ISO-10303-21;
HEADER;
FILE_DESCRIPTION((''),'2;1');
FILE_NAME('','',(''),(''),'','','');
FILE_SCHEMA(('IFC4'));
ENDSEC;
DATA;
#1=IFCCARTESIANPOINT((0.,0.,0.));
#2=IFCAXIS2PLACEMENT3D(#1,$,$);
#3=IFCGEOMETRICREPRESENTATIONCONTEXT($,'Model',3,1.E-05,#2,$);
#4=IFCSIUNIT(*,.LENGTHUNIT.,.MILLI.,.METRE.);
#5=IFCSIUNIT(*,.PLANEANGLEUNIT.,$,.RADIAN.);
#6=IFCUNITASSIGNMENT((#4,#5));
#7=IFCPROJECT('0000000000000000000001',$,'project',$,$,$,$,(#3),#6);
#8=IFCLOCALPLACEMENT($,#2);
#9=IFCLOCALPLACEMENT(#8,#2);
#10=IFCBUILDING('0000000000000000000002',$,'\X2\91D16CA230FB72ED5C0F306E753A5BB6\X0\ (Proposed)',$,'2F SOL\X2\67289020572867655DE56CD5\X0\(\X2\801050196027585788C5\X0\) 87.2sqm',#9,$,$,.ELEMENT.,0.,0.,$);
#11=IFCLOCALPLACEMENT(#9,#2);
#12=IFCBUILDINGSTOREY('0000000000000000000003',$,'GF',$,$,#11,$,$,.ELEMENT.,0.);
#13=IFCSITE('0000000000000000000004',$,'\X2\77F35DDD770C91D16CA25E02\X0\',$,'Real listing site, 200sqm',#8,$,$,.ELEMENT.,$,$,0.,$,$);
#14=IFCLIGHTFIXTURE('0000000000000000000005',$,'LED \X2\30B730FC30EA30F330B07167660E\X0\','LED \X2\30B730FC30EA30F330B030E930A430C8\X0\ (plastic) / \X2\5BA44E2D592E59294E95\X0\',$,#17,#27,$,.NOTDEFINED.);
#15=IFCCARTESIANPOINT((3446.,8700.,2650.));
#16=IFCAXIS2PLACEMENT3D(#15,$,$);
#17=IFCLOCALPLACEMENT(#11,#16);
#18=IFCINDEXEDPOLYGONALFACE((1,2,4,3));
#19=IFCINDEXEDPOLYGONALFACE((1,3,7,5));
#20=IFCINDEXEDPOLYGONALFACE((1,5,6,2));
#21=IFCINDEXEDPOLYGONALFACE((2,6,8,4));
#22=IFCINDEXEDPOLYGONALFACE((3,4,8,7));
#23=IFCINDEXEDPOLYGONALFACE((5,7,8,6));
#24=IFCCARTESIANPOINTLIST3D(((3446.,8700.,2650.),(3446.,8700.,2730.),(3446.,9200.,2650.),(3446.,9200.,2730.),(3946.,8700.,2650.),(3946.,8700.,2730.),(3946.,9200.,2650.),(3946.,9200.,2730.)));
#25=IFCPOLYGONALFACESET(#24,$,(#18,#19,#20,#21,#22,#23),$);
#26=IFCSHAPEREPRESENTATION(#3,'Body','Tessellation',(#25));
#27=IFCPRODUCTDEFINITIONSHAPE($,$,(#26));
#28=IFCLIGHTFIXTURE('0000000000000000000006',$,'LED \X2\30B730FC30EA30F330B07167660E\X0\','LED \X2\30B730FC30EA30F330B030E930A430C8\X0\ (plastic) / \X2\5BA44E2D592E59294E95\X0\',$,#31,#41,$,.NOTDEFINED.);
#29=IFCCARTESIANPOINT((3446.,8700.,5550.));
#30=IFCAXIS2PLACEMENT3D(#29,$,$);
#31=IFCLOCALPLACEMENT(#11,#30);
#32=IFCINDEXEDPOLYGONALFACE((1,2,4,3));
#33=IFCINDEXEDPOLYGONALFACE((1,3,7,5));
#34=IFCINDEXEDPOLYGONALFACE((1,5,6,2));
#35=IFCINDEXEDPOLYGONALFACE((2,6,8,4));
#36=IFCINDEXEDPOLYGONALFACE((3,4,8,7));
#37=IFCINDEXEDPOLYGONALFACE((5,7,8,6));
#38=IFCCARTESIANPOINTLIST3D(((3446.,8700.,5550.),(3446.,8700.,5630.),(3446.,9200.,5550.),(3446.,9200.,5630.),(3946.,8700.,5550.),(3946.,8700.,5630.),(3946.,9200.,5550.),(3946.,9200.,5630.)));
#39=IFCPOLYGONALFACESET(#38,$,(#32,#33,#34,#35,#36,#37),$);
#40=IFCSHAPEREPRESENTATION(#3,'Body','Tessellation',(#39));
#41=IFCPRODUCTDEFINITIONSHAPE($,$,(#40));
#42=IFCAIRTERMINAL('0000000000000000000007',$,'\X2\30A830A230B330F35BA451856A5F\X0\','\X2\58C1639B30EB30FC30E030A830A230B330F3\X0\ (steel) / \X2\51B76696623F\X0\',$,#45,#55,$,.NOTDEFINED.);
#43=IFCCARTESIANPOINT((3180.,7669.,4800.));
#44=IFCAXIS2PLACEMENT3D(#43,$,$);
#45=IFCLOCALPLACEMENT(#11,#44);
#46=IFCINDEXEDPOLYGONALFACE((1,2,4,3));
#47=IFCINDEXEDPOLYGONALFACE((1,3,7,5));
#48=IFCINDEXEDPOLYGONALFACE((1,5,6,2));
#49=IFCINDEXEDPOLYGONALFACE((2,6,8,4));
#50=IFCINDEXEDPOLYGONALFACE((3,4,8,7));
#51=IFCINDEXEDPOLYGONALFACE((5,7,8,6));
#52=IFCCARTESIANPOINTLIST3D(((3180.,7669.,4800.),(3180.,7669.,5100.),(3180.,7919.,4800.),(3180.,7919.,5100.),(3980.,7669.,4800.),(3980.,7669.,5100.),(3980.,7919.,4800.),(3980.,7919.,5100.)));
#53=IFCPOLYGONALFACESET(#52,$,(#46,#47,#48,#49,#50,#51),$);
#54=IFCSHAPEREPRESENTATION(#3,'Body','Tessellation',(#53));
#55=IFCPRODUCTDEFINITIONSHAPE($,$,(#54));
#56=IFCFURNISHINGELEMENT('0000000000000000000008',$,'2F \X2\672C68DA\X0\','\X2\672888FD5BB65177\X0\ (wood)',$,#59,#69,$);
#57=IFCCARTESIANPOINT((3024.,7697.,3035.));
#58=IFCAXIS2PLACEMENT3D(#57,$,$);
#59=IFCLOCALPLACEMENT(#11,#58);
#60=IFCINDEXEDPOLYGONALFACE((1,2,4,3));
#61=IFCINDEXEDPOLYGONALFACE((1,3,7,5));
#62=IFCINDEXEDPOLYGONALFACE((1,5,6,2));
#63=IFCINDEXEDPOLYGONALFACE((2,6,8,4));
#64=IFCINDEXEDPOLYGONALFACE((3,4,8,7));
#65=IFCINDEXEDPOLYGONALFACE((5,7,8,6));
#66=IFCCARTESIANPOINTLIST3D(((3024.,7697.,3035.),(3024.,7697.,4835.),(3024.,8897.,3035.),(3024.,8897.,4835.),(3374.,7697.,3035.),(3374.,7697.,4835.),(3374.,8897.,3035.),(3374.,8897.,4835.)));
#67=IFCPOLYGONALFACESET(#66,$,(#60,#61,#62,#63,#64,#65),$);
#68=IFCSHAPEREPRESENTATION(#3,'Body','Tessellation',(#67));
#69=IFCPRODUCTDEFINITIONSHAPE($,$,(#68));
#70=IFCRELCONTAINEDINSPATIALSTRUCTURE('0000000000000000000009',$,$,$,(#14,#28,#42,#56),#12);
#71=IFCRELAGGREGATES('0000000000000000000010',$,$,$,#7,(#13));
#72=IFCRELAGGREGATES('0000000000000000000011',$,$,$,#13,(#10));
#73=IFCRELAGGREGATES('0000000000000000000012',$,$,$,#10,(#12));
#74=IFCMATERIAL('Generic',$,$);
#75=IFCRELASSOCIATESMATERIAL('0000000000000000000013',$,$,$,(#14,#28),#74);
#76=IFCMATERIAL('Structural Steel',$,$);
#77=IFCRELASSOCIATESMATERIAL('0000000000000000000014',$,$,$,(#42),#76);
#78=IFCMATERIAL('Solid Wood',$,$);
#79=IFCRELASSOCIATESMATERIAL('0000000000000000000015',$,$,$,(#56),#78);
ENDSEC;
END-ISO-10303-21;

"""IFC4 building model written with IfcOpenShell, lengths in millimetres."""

from ifc_helpers import new_model, si_unit, frame, frame_2d, origin, place, context, project, spatial, rectangle, extrude, material, element, save


model = new_model("IFC4")

# Units and contexts
model_context = context("Model", 3, precision=1e-05, world=origin())
ifc_project = project(units=[si_unit("LENGTHUNIT", "METRE", prefix="MILLI"), si_unit("PLANEANGLEUNIT", "RADIAN")], contexts=[model_context])

# Site, building, storey
site_placement = place(None, origin())
site = spatial("IfcSite", under=ifc_project, at=site_placement, Name="石川県金沢市", ObjectType="Real listing site, 200sqm", CompositionType="ELEMENT", RefElevation=0.0)
building_placement = place(site_placement, origin())
building = spatial("IfcBuilding", under=site, at=building_placement, Name="金沢・狭小の町家 (Proposed)", ObjectType="2F SOL木造在来工法(耐候性塗装) 87.2sqm", CompositionType="ELEMENT", ElevationOfRefHeight=0.0, ElevationOfTerrain=0.0)
storey_placement = place(building_placement, origin())
storey = spatial("IfcBuildingStorey", under=building, at=storey_placement, Name="GF", CompositionType="ELEMENT", Elevation=0.0)

# Shared definitions
ifc_material_1 = material(Name="Solid Wood")

# Shared definitions
ifc_material_2 = material(Name="Structural Steel")

# Shared definitions
ifc_material_3 = material(Name="Generic")

# Light fixtures
light_fixture_1_placement = place(storey_placement, frame((3446.0, 8700.0, 2650.0)))
element("IfcLightFixture", 1, at=light_fixture_1_placement, inside=storey, material=ifc_material_3, Name="LED シーリング照明", Description="LED シーリングライト (plastic) / 室中央天井", PredefinedType="NOTDEFINED", context=model_context, shape_type="SweptSolid", body=[
    extrude(rectangle(XDim=500.0, YDim=500.0, at=frame_2d((250.0, 250.0))), frame((3446.0, 8700.0, 2650.0)), (0.0, 0.0, 1.0), 80.0),
])
light_fixture_2_placement = place(storey_placement, frame((3446.0, 8700.0, 5550.0)))
element("IfcLightFixture", 2, at=light_fixture_2_placement, inside=storey, material=ifc_material_3, Name="LED シーリング照明", Description="LED シーリングライト (plastic) / 室中央天井", PredefinedType="NOTDEFINED", context=model_context, shape_type="SweptSolid", body=[
    extrude(rectangle(XDim=500.0, YDim=500.0, at=frame_2d((250.0, 250.0))), frame((3446.0, 8700.0, 5550.0)), (0.0, 0.0, 1.0), 80.0),
])

# Air terminal
air_terminal_placement = place(storey_placement, frame((3180.0, 7669.0, 4800.0)))
element("IfcAirTerminal", 3, at=air_terminal_placement, inside=storey, material=ifc_material_2, Name="エアコン室内機", Description="壁掛ルームエアコン (steel) / 冷暖房", PredefinedType="NOTDEFINED", context=model_context, shape_type="SweptSolid", body=[
    extrude(rectangle(XDim=800.0, YDim=250.0, at=frame_2d((400.0, 125.0))), frame((3180.0, 7669.0, 4800.0)), (0.0, 0.0, 1.0), 300.0),
])

# Furnishing element
furnishing_placement = place(storey_placement, frame((3024.0, 7697.0, 3035.0)))
element("IfcFurnishingElement", 4, at=furnishing_placement, inside=storey, material=ifc_material_1, Name="2F 本棚", Description="木製家具 (wood)", context=model_context, shape_type="SweptSolid", body=[
    extrude(rectangle(XDim=350.0, YDim=1200.0, at=frame_2d((175.0, 600.0))), frame((3024.0, 7697.0, 3035.0)), (0.0, 0.0, 1.0), 1800.0),
])

save(model, "model.ifc")
